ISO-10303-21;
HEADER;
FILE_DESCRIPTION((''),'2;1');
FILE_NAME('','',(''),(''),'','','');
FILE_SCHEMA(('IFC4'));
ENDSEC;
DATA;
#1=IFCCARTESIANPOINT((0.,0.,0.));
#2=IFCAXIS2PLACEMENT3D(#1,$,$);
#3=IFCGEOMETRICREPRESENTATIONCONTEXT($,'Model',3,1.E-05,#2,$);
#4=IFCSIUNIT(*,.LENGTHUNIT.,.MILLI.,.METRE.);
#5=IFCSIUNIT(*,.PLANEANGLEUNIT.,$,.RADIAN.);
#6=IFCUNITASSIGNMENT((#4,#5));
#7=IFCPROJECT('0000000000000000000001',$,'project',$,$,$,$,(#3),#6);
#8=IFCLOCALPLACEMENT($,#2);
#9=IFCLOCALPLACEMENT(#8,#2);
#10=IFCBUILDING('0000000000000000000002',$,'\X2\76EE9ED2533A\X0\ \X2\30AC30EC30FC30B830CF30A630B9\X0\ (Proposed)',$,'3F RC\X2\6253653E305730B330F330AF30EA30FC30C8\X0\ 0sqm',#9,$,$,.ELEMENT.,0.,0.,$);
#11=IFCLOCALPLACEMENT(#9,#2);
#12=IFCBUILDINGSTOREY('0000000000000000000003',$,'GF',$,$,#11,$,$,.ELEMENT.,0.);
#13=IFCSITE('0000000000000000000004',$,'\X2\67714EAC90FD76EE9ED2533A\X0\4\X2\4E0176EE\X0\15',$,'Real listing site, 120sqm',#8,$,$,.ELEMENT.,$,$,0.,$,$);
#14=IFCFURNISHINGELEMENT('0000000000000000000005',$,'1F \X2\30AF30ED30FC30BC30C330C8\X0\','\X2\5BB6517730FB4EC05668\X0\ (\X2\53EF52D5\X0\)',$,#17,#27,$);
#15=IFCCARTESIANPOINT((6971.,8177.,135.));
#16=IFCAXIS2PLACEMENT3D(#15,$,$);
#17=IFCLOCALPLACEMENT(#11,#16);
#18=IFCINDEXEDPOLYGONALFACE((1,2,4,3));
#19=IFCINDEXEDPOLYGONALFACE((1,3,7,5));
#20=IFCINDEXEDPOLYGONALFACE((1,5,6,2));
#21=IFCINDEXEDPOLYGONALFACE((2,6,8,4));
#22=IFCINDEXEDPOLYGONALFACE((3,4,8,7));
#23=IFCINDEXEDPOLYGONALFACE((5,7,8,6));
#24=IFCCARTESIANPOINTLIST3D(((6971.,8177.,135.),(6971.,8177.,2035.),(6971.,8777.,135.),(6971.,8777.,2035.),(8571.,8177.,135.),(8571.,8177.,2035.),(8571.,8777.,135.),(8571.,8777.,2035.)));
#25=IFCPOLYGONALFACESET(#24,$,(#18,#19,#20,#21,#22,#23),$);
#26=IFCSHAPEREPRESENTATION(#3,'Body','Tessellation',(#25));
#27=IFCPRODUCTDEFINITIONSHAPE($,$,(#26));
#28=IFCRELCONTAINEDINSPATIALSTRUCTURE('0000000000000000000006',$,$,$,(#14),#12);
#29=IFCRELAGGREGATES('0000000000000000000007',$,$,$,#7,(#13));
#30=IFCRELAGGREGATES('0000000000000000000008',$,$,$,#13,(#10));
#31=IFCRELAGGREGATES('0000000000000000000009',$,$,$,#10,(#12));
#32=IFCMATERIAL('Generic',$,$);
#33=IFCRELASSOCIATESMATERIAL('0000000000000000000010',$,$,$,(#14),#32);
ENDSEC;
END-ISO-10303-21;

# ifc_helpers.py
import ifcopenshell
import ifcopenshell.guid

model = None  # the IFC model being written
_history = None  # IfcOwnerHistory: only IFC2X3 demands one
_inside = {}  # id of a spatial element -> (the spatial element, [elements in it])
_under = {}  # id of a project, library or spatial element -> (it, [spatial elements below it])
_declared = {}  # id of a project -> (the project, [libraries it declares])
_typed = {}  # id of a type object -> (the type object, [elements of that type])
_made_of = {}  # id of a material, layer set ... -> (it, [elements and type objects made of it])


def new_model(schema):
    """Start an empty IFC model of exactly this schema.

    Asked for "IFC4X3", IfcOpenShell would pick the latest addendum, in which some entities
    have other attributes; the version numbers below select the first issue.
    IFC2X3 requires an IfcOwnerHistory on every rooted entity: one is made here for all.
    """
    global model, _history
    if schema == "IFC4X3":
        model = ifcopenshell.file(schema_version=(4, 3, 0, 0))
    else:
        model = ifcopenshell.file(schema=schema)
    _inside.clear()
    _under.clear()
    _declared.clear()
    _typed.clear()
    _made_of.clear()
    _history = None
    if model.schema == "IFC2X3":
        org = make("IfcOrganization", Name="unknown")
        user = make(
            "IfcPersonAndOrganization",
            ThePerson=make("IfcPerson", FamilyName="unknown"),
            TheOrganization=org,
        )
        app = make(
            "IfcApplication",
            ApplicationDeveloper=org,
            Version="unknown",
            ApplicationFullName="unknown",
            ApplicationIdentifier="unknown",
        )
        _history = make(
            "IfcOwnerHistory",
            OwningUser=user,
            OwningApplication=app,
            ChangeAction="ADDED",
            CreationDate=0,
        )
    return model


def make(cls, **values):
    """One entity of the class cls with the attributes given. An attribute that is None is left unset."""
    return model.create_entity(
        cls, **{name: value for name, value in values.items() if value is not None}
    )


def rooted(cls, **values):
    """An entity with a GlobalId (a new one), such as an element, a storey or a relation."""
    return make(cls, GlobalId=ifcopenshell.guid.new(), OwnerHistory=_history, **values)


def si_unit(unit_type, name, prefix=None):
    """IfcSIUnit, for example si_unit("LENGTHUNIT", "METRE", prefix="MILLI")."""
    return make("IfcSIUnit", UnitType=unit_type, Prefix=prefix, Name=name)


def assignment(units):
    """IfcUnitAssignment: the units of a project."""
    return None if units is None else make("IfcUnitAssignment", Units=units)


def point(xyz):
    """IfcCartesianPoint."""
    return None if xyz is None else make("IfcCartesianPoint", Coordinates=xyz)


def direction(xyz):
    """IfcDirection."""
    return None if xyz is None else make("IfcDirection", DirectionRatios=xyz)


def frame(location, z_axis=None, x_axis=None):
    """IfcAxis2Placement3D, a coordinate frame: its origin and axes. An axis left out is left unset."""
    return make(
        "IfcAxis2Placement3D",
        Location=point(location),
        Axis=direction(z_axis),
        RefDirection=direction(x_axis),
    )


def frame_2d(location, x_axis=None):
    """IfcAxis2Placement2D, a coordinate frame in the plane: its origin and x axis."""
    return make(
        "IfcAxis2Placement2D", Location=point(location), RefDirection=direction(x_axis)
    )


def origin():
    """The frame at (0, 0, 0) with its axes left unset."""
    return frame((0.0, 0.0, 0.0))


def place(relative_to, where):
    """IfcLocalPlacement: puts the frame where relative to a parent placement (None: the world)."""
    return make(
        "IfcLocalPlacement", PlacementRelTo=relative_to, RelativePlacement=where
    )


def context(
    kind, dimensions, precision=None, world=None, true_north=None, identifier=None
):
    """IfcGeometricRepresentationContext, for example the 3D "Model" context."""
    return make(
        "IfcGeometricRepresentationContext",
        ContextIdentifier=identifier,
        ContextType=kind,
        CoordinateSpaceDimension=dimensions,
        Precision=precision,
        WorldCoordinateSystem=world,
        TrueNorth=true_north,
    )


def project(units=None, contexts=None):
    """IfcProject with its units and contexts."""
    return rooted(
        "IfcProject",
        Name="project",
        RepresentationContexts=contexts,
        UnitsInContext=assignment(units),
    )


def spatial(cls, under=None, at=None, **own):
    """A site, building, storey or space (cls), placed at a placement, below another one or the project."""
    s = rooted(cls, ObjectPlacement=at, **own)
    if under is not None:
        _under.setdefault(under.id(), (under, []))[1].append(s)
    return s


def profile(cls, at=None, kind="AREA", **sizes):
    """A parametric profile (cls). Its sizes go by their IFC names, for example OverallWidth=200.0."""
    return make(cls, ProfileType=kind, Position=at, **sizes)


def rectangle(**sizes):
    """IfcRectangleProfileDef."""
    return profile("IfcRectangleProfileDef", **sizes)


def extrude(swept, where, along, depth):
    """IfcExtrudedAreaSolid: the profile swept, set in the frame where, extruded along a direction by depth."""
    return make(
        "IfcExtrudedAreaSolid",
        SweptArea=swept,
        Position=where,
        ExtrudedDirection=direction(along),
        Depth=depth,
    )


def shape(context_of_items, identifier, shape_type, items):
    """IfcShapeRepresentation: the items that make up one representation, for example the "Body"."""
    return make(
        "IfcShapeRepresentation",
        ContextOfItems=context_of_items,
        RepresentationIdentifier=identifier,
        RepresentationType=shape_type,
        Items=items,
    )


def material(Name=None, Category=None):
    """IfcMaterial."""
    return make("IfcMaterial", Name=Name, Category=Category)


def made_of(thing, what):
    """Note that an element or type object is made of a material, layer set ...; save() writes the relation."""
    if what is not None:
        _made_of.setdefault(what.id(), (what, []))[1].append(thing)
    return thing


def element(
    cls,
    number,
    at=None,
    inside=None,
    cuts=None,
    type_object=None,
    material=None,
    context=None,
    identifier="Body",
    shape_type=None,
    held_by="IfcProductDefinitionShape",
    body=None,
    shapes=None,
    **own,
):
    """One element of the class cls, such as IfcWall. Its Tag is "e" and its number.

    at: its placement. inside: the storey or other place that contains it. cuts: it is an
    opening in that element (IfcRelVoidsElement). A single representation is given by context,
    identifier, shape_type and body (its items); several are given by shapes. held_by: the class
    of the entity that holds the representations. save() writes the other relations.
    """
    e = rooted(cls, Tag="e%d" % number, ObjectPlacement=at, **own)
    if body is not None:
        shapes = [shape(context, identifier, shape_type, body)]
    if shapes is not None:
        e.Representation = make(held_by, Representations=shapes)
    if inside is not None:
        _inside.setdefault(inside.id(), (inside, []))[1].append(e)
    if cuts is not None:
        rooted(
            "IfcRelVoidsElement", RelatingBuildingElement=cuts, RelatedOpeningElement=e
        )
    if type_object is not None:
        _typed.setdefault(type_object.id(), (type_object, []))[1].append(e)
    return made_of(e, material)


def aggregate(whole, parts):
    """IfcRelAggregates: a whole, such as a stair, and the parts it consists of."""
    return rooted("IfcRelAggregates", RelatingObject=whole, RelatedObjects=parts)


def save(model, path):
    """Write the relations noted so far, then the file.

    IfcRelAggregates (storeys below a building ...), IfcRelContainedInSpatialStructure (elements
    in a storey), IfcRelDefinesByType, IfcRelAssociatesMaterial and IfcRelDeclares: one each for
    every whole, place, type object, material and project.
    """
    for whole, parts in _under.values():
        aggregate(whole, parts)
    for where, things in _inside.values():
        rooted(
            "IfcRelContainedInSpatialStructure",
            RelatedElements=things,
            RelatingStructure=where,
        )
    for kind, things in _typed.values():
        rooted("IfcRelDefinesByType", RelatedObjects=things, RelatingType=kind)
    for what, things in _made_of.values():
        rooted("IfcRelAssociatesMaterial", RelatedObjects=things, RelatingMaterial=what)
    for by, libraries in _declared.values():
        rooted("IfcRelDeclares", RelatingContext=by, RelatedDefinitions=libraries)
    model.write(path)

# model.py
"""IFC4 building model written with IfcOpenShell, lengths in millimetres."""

from ifc_helpers import new_model, si_unit, frame, frame_2d, origin, place, context, project, spatial, rectangle, extrude, material, element, save


model = new_model("IFC4")

# Units and contexts
model_context = context("Model", 3, precision=1e-05, world=origin())
ifc_project = project(units=[si_unit("LENGTHUNIT", "METRE", prefix="MILLI"), si_unit("PLANEANGLEUNIT", "RADIAN")], contexts=[model_context])

# Site, building, storey
site_placement = place(None, origin())
site = spatial("IfcSite", under=ifc_project, at=site_placement, Name="東京都目黒区4丁目15", ObjectType="Real listing site, 120sqm", CompositionType="ELEMENT", RefElevation=0.0)
building_placement = place(site_placement, origin())
building = spatial("IfcBuilding", under=site, at=building_placement, Name="目黒区 ガレージハウス (Proposed)", ObjectType="3F RC打放しコンクリート 0sqm", CompositionType="ELEMENT", ElevationOfRefHeight=0.0, ElevationOfTerrain=0.0)
storey_placement = place(building_placement, origin())
storey = spatial("IfcBuildingStorey", under=building, at=storey_placement, Name="GF", CompositionType="ELEMENT", Elevation=0.0)

# Shared definitions
ifc_material_1 = material(Name="Generic")

# Furnishing element
furnishing_placement = place(storey_placement, frame((6971.0, 8177.0, 135.0)))
element("IfcFurnishingElement", 1, at=furnishing_placement, inside=storey, material=ifc_material_1, Name="1F クローゼット", Description="家具・什器 (可動)", context=model_context, shape_type="SweptSolid", body=[
    extrude(rectangle(XDim=1600.0, YDim=600.0, at=frame_2d((800.0, 300.0))), frame((6971.0, 8177.0, 135.0)), (0.0, 0.0, 1.0), 1900.0),
])

save(model, "model.ifc")
